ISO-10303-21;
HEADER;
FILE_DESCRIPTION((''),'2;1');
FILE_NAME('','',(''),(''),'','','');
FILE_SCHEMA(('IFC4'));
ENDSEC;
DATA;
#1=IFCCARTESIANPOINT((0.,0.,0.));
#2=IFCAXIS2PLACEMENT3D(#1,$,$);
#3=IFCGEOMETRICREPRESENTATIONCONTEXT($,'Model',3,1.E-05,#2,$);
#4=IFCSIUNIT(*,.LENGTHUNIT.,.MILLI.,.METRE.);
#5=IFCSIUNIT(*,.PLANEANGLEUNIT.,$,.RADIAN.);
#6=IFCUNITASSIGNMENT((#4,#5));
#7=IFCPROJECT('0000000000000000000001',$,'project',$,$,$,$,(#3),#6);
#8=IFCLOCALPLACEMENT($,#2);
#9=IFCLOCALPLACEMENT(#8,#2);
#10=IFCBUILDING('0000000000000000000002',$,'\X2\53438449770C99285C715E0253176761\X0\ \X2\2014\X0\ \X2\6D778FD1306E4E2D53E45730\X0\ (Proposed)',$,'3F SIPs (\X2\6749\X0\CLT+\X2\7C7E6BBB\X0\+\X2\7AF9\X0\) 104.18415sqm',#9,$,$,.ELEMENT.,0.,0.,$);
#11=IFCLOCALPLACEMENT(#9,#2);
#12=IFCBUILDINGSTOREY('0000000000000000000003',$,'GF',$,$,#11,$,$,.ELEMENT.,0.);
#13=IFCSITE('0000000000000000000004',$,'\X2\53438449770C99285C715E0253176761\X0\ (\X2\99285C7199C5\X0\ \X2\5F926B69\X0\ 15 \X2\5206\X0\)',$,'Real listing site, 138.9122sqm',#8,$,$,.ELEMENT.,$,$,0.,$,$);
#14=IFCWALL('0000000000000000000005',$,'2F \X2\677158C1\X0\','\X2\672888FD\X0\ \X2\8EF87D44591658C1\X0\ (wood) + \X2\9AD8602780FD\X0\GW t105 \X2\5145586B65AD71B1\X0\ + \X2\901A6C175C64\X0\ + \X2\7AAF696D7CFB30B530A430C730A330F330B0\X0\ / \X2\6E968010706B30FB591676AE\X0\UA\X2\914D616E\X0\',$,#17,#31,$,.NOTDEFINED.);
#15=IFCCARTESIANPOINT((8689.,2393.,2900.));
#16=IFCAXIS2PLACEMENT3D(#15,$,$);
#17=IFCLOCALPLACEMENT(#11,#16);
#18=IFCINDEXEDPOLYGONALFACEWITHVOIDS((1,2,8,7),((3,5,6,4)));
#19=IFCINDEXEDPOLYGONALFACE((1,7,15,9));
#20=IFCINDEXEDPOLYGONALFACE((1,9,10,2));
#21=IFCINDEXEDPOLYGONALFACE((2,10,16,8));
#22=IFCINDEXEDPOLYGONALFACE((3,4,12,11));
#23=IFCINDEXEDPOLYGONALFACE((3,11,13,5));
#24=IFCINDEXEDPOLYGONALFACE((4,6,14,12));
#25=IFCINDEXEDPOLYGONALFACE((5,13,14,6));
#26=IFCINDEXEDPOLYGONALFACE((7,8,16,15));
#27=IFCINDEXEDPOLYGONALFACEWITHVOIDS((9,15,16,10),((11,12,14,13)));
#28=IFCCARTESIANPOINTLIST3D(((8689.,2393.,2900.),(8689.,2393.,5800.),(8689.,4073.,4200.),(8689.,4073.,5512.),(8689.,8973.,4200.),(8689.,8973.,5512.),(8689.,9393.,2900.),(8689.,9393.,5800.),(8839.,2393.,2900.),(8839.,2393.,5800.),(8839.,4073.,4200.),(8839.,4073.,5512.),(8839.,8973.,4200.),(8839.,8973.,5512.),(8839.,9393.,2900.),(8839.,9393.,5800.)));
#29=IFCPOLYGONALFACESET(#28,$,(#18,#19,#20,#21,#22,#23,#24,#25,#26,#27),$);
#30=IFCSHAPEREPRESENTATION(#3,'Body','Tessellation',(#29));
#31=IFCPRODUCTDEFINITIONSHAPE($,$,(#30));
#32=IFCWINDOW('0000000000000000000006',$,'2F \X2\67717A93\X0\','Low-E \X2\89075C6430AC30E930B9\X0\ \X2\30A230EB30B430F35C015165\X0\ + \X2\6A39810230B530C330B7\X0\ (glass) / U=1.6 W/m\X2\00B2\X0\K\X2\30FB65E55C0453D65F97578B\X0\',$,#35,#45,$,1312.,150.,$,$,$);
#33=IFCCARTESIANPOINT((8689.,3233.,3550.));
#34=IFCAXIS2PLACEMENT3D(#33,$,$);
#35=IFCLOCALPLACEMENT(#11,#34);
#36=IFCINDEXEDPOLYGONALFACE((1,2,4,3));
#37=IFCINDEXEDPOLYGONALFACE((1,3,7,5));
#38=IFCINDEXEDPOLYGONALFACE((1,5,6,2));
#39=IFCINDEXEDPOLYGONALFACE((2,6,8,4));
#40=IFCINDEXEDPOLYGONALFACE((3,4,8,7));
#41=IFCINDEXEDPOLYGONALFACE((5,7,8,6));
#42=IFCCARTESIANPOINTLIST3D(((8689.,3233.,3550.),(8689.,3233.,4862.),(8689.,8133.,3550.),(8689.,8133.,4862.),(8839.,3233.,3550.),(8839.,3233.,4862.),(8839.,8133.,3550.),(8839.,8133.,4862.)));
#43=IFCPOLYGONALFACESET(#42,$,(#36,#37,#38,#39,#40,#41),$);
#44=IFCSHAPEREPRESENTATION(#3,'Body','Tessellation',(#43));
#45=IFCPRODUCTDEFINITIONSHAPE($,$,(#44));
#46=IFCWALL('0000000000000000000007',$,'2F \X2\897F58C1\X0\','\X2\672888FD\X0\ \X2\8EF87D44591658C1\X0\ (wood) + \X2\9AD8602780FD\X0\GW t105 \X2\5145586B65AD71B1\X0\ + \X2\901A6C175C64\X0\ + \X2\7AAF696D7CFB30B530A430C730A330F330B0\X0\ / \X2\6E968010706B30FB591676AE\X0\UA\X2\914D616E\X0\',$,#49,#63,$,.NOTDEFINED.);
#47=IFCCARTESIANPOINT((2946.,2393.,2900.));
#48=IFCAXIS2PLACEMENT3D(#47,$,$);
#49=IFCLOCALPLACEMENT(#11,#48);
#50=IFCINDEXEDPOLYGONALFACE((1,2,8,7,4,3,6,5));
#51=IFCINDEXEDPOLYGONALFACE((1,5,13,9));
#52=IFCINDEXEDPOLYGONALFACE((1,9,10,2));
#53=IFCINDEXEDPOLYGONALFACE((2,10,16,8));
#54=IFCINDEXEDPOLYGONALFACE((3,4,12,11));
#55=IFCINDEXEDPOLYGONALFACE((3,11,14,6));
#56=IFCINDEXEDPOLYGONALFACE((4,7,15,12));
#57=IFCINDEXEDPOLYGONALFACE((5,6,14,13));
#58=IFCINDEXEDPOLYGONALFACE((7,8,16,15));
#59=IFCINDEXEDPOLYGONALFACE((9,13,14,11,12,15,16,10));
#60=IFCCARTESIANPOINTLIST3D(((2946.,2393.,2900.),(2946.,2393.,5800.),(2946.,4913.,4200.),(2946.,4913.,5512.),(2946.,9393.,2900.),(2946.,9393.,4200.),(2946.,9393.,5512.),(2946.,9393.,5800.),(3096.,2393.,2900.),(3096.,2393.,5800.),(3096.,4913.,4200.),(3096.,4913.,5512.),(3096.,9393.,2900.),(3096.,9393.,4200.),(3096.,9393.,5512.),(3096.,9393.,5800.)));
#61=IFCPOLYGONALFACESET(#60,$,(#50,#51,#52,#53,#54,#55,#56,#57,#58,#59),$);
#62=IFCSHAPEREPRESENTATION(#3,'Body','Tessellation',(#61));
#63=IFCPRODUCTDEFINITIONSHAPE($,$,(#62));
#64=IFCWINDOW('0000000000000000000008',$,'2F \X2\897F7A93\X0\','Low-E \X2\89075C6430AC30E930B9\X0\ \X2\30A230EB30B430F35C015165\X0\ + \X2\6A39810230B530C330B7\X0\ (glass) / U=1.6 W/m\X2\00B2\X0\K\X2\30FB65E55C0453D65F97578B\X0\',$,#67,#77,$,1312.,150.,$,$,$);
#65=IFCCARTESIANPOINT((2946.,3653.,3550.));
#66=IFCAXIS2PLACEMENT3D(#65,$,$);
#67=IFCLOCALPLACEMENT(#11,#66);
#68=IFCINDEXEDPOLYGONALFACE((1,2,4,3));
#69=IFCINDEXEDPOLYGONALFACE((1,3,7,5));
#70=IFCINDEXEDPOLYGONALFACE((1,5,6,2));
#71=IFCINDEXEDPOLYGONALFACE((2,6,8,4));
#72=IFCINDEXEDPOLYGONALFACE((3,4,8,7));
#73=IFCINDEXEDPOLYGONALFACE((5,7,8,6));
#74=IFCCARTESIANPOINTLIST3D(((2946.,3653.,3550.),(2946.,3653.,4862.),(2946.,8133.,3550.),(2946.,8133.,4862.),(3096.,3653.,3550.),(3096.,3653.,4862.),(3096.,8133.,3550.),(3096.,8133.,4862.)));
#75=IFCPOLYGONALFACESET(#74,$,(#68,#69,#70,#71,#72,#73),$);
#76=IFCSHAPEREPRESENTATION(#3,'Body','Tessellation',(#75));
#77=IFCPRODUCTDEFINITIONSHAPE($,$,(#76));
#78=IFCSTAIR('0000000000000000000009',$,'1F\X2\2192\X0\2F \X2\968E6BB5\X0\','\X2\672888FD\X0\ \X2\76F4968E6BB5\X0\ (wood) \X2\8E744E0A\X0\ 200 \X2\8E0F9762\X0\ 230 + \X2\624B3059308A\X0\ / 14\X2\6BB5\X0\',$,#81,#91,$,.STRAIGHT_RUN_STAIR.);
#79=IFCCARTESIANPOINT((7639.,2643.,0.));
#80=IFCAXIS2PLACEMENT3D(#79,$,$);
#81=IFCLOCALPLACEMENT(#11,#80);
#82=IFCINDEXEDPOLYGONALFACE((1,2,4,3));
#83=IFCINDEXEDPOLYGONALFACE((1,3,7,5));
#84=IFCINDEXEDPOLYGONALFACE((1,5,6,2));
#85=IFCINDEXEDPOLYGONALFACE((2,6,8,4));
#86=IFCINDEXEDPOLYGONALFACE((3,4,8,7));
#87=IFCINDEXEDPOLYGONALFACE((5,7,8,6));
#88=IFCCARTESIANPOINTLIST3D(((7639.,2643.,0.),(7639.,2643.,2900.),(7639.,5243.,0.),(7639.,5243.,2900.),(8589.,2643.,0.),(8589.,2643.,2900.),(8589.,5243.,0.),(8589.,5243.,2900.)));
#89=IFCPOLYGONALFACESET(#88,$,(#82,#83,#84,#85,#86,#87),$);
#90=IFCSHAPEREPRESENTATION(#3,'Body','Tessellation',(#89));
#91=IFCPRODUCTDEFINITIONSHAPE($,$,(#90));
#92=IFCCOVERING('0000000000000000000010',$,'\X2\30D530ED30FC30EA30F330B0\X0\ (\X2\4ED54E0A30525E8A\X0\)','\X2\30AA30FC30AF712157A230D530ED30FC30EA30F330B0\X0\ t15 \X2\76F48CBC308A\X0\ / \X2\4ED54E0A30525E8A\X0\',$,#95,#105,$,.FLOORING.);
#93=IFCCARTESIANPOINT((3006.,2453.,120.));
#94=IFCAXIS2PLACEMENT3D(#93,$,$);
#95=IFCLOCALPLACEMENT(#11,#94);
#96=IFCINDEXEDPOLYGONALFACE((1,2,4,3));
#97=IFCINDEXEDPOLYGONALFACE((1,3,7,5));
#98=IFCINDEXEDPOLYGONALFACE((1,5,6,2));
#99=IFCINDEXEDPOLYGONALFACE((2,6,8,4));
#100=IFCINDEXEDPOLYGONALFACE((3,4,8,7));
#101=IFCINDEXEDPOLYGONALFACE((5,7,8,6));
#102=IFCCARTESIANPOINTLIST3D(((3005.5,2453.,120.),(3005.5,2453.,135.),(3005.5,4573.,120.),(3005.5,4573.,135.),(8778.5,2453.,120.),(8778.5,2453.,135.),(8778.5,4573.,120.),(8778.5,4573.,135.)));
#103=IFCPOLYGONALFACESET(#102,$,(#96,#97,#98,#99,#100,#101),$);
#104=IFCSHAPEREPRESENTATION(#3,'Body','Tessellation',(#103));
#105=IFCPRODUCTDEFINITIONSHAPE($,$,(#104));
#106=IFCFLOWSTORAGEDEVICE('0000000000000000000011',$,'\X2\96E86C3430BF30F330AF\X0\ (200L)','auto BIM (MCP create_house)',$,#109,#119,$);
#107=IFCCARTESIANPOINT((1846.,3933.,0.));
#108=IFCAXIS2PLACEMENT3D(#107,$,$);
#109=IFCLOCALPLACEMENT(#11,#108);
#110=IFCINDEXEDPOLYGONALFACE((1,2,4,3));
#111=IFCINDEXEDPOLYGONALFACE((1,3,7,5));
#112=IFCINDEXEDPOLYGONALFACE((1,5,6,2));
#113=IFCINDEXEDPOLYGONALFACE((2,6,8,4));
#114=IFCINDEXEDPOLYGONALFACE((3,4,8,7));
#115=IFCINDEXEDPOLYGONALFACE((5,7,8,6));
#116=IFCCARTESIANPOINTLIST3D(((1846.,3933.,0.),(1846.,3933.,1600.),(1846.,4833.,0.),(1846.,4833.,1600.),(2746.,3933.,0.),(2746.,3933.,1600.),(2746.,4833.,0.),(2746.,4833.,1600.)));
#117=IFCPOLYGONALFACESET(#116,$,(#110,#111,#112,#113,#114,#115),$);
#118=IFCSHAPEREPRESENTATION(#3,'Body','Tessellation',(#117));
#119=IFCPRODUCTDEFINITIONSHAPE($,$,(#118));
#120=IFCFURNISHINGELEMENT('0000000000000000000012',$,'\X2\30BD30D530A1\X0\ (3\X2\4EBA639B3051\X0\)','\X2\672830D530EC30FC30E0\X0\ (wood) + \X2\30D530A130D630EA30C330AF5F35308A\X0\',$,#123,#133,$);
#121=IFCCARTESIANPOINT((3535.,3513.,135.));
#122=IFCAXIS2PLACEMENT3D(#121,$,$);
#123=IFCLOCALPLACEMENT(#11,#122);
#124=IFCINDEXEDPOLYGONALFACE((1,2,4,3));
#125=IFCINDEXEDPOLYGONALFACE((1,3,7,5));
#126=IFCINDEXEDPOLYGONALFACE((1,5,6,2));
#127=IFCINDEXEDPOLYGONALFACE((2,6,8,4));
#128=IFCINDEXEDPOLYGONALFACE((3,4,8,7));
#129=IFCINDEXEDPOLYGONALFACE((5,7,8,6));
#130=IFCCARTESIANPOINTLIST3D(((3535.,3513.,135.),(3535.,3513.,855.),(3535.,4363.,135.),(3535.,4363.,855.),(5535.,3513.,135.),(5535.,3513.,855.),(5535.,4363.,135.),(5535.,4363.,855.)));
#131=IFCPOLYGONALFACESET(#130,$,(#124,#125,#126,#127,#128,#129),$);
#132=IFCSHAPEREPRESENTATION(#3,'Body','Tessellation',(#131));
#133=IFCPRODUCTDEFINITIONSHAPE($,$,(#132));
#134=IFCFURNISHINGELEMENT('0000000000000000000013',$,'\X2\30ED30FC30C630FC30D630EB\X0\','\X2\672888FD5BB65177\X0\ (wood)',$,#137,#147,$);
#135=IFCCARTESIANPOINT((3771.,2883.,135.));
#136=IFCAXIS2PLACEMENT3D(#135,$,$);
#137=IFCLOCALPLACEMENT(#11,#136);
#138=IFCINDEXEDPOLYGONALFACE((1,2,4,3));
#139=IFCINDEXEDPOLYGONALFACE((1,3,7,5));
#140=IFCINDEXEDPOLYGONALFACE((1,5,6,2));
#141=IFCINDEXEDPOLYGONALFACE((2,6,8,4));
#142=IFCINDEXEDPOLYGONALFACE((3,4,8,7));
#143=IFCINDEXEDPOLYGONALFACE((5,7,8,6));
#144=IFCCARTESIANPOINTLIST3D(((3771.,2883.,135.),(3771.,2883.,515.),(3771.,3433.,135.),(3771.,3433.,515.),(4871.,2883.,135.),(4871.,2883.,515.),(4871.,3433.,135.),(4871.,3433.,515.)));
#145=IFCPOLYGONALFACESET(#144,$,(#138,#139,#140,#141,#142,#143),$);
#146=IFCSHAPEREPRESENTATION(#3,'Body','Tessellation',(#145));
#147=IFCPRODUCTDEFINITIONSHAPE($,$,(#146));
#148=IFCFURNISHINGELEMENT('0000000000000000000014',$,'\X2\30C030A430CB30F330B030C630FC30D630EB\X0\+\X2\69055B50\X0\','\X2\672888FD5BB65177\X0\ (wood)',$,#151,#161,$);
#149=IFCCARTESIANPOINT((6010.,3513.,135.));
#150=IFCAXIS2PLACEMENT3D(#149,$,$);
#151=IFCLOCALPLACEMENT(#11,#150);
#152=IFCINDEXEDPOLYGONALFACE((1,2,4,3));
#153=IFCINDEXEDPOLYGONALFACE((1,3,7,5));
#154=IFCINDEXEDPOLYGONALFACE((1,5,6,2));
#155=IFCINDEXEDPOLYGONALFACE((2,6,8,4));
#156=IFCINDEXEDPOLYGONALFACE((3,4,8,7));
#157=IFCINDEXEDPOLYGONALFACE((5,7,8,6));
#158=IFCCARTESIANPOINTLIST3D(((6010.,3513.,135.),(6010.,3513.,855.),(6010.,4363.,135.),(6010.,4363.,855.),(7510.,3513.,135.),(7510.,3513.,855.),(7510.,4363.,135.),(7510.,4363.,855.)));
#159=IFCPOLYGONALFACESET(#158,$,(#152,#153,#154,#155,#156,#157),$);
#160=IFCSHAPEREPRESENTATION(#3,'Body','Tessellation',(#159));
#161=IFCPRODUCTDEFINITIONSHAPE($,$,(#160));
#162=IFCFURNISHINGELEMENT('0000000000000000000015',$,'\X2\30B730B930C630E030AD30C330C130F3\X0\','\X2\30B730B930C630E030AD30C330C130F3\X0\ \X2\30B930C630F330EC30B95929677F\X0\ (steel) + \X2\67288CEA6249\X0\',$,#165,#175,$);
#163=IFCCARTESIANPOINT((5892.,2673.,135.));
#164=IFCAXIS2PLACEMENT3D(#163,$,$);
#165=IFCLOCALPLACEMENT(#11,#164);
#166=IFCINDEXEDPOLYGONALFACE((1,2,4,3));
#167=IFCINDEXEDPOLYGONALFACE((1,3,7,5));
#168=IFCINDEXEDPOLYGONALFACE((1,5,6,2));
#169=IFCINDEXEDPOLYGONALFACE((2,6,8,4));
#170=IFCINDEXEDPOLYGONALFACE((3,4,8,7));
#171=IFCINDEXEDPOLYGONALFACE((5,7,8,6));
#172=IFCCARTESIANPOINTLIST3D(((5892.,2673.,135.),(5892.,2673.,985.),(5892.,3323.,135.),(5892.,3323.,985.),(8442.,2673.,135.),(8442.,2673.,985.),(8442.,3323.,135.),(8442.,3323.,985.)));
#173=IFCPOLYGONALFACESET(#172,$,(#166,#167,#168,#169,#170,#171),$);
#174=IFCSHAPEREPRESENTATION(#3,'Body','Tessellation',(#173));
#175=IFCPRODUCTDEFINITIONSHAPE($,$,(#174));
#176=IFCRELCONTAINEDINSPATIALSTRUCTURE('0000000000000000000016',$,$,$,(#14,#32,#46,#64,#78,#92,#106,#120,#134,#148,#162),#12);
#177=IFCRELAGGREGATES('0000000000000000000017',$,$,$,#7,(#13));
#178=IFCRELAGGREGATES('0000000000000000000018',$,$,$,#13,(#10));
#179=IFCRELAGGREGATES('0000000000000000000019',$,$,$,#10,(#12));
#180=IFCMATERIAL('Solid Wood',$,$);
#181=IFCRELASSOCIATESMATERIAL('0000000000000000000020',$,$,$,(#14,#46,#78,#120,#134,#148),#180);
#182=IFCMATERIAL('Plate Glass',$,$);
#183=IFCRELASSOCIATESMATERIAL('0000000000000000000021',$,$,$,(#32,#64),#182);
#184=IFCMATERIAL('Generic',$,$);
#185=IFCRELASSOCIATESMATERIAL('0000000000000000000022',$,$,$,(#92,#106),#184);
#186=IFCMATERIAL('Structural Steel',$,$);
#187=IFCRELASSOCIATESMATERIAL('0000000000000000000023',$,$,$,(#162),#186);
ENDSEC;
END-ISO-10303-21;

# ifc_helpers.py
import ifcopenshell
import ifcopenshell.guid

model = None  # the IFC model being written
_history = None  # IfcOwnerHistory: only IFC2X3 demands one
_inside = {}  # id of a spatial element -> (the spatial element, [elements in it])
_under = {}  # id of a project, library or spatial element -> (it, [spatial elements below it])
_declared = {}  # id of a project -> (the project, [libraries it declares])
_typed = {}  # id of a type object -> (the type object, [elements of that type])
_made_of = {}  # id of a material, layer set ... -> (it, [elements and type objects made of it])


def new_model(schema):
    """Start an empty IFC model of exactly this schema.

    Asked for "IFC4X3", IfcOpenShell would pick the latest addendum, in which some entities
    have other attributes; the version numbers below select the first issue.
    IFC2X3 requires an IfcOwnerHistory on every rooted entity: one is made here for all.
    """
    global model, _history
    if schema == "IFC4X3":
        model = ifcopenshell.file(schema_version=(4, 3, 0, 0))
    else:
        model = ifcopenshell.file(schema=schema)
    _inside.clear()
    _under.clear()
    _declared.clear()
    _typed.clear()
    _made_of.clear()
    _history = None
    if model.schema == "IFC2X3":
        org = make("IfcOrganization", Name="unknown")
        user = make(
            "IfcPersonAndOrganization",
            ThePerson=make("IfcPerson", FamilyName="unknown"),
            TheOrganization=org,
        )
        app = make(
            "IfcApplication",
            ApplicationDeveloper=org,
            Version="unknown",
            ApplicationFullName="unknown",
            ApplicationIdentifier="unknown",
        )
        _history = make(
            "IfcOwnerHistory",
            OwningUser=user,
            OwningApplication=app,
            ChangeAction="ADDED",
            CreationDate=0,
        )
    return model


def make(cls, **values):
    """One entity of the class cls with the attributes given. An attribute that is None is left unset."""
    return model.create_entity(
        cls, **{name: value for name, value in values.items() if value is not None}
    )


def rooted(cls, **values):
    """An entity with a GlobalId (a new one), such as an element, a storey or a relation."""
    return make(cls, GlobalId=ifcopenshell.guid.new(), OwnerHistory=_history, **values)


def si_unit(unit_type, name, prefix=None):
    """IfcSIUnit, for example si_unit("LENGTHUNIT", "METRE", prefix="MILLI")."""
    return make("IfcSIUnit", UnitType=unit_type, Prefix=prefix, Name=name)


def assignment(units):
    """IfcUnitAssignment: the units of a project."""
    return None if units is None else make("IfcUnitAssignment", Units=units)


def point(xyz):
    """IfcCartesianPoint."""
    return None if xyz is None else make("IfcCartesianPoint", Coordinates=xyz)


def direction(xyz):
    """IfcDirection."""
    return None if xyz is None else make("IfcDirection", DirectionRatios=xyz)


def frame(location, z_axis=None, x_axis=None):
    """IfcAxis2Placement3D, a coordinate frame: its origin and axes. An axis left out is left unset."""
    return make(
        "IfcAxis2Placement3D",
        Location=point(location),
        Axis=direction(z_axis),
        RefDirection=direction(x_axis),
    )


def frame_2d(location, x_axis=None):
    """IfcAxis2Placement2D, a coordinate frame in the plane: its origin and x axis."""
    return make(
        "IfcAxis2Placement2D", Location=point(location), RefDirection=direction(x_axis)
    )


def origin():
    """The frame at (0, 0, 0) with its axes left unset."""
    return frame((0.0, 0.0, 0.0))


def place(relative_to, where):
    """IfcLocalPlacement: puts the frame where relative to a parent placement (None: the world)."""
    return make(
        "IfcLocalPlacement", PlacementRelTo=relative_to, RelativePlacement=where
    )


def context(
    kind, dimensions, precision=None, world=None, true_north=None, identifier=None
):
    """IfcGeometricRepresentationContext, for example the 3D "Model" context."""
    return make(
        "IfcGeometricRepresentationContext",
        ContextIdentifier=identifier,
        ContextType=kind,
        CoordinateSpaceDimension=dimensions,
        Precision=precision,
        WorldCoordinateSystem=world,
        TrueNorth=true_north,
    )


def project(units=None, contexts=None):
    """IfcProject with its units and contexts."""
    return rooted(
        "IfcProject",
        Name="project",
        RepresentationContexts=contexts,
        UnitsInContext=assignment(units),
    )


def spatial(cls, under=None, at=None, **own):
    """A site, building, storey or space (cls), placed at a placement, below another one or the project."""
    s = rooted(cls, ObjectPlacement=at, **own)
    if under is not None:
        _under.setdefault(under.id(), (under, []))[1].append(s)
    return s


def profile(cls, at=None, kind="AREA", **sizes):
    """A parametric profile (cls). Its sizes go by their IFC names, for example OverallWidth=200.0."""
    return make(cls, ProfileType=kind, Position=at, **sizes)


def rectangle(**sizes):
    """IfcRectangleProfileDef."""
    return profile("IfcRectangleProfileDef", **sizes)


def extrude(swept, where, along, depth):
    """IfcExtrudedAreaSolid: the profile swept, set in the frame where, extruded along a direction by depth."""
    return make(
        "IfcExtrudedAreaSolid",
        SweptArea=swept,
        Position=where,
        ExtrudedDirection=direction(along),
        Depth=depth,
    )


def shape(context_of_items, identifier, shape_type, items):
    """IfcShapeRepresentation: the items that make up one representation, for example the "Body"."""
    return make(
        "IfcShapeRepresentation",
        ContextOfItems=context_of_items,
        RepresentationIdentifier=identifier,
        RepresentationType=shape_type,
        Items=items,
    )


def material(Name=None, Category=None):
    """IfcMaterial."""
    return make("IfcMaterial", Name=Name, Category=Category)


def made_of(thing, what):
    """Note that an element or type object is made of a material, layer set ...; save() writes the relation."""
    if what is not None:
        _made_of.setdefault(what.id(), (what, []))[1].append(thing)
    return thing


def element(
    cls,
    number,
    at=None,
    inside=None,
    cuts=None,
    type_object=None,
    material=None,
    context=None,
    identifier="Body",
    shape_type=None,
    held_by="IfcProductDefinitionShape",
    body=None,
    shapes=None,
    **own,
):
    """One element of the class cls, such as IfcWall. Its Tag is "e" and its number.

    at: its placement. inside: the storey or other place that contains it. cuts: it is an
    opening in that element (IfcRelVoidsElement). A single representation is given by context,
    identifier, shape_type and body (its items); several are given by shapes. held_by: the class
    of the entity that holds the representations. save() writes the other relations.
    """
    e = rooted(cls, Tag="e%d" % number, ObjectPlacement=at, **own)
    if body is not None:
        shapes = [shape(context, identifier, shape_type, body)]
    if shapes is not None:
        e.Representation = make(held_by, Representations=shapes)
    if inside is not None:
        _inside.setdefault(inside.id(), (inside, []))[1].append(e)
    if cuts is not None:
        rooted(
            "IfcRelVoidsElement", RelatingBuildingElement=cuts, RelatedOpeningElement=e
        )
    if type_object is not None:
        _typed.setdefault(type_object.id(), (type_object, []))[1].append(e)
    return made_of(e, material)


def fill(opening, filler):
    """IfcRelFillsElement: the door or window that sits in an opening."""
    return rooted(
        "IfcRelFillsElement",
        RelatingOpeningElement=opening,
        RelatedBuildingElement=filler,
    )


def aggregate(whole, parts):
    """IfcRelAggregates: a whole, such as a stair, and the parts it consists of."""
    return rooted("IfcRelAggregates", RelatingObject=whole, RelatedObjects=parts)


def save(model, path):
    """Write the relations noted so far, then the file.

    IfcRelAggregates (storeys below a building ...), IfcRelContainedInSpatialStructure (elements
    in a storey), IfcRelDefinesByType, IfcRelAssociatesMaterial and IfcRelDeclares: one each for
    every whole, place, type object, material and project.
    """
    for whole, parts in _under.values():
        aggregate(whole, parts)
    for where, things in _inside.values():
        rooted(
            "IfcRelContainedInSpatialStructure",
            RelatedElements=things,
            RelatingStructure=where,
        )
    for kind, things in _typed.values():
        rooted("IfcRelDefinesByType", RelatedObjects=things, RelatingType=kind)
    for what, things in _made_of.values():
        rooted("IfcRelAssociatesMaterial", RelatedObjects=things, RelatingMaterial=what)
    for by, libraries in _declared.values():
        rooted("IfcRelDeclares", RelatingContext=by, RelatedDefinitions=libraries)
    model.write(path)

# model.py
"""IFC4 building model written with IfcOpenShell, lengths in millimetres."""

from ifc_helpers import new_model, si_unit, frame, frame_2d, origin, place, context, project, spatial, rectangle, extrude, material, element, fill, save


model = new_model("IFC4")

# Units and contexts
model_context = context("Model", 3, precision=1e-05, world=origin())
ifc_project = project(units=[si_unit("LENGTHUNIT", "METRE", prefix="MILLI"), si_unit("PLANEANGLEUNIT", "RADIAN")], contexts=[model_context])

# Site, building, storey
site_placement = place(None, origin())
site = spatial("IfcSite", under=ifc_project, at=site_placement, Name="千葉県館山市北条 (館山駅 徒歩 15 分)", ObjectType="Real listing site, 138.9122sqm", CompositionType="ELEMENT", RefElevation=0.0)
building_placement = place(site_placement, origin())
building = spatial("IfcBuilding", under=site, at=building_placement, Name="千葉県館山市北条 — 海近の中古地 (Proposed)", ObjectType="3F SIPs (杉CLT+籾殻+竹) 104.18415sqm", CompositionType="ELEMENT", ElevationOfRefHeight=0.0, ElevationOfTerrain=0.0)
storey_placement = place(building_placement, origin())
storey = spatial("IfcBuildingStorey", under=building, at=storey_placement, Name="GF", CompositionType="ELEMENT", Elevation=0.0)

# Shared definitions
ifc_material_1 = material(Name="Solid Wood")

# Shared definitions
ifc_material_2 = material(Name="Plate Glass")

# Walls, openings, windows
wall_1_placement = place(storey_placement, frame((8689.0, 2393.0, 2900.0)))
wall_1 = element("IfcWall", 1, at=wall_1_placement, inside=storey, material=ifc_material_1, Name="2F 東壁", Description="木製 軸組外壁 (wood) + 高性能GW t105 充填断熱 + 通気層 + 窯業系サイディング / 準耐火・外皮UA配慮", PredefinedType="NOTDEFINED", context=model_context, shape_type="SweptSolid", body=[
    extrude(rectangle(XDim=150.0, YDim=7000.0, at=frame_2d((75.0, 3500.0))), frame((8689.0, 2393.0, 2900.0)), (0.0, 0.0, 1.0), 2900.0),
])
opening_1_placement = place(storey_placement, frame((8689.0, 3233.0, 3550.0)))
opening_1 = element("IfcOpeningElement", 2, at=opening_1_placement, cuts=wall_1, PredefinedType="NOTDEFINED", context=model_context, shape_type="SweptSolid", body=[
    extrude(rectangle(XDim=150.0, YDim=4900.0, at=frame_2d((75.0, 2450.0))), frame((8689.0, 3233.0, 3550.0)), (0.0, 0.0, 1.0), 1312.0),
])
window_1_placement = place(storey_placement, frame((8689.0, 3233.0, 3550.0)))
window_1 = element("IfcWindow", 3, at=window_1_placement, inside=storey, material=ifc_material_2, Name="2F 東窓", Description="Low-E 複層ガラス アルゴン封入 + 樹脂サッシ (glass) / U=1.6 W/m²K・日射取得型", OverallHeight=1312.0, OverallWidth=150.0, context=model_context, shape_type="SweptSolid", body=[
    extrude(rectangle(XDim=150.0, YDim=4900.0, at=frame_2d((75.0, 2450.0))), frame((8689.0, 3233.0, 3550.0)), (0.0, 0.0, 1.0), 1312.0),
])
fill(opening_1, window_1)
wall_2_placement = place(storey_placement, frame((2946.0, 2393.0, 2900.0)))
wall_2 = element("IfcWall", 4, at=wall_2_placement, inside=storey, material=ifc_material_1, Name="2F 西壁", Description="木製 軸組外壁 (wood) + 高性能GW t105 充填断熱 + 通気層 + 窯業系サイディング / 準耐火・外皮UA配慮", PredefinedType="NOTDEFINED", context=model_context, shape_type="SweptSolid", body=[
    extrude(rectangle(XDim=150.0, YDim=7000.0, at=frame_2d((75.0, 3500.0))), frame((2946.0, 2393.0, 2900.0)), (0.0, 0.0, 1.0), 2900.0),
])
opening_2_placement = place(storey_placement, frame((2946.0, 3653.0, 3550.0)))
opening_2 = element("IfcOpeningElement", 5, at=opening_2_placement, cuts=wall_2, PredefinedType="NOTDEFINED", context=model_context, shape_type="SweptSolid", body=[
    extrude(rectangle(XDim=150.0, YDim=4480.0, at=frame_2d((75.0, 2240.0))), frame((2946.0, 3653.0, 3550.0)), (0.0, 0.0, 1.0), 1312.0),
])
window_2_placement = place(storey_placement, frame((2946.0, 3653.0, 3550.0)))
window_2 = element("IfcWindow", 6, at=window_2_placement, inside=storey, material=ifc_material_2, Name="2F 西窓", Description="Low-E 複層ガラス アルゴン封入 + 樹脂サッシ (glass) / U=1.6 W/m²K・日射取得型", OverallHeight=1312.0, OverallWidth=150.0, context=model_context, shape_type="SweptSolid", body=[
    extrude(rectangle(XDim=150.0, YDim=4480.0, at=frame_2d((75.0, 2240.0))), frame((2946.0, 3653.0, 3550.0)), (0.0, 0.0, 1.0), 1312.0),
])
fill(opening_2, window_2)

# Stair
stair_placement = place(storey_placement, frame((7639.0, 2643.0, 0.0)))
element("IfcStair", 7, at=stair_placement, inside=storey, material=ifc_material_1, Name="1F→2F 階段", Description="木製 直階段 (wood) 蹴上 200 踏面 230 + 手すり / 14段", PredefinedType="STRAIGHT_RUN_STAIR", context=model_context, shape_type="SweptSolid", body=[
    extrude(rectangle(XDim=950.0, YDim=2600.0, at=frame_2d((475.0, 1300.0))), frame((7639.0, 2643.0, 0.0)), (0.0, 0.0, 1.0), 2900.0),
])

# Covering
ifc_material_3 = material(Name="Generic")
covering_placement = place(storey_placement, frame((3006.0, 2453.0, 120.0)))
element("IfcCovering", 8, at=covering_placement, inside=storey, material=ifc_material_3, Name="フローリング (仕上げ床)", Description="オーク無垢フローリング t15 直貼り / 仕上げ床", PredefinedType="FLOORING", context=model_context, shape_type="SweptSolid", body=[
    extrude(rectangle(XDim=5773.0, YDim=2120.0, at=frame_2d((2886.0, 1060.0))), frame((3006.0, 2453.0, 120.0)), (0.0, 0.0, 1.0), 15.0),
])

# Flow storage device
flow_storage_device_placement = place(storey_placement, frame((1846.0, 3933.0, 0.0)))
element("IfcFlowStorageDevice", 9, at=flow_storage_device_placement, inside=storey, material=ifc_material_3, Name="雨水タンク (200L)", Description="auto BIM (MCP create_house)", context=model_context, shape_type="SweptSolid", body=[
    extrude(rectangle(XDim=900.0, YDim=900.0, at=frame_2d((450.0, 450.0))), frame((1846.0, 3933.0, 0.0)), (0.0, 0.0, 1.0), 1600.0),
])

# Furnishing elements
furnishing_1_placement = place(storey_placement, frame((3535.0, 3513.0, 135.0)))
element("IfcFurnishingElement", 10, at=furnishing_1_placement, inside=storey, material=ifc_material_1, Name="ソファ (3人掛け)", Description="木フレーム (wood) + ファブリック張り", context=model_context, shape_type="SweptSolid", body=[
    extrude(rectangle(XDim=2000.0, YDim=850.0, at=frame_2d((1000.0, 425.0))), frame((3535.0, 3513.0, 135.0)), (0.0, 0.0, 1.0), 720.0),
])
furnishing_2_placement = place(storey_placement, frame((3771.0, 2883.0, 135.0)))
element("IfcFurnishingElement", 11, at=furnishing_2_placement, inside=storey, material=ifc_material_1, Name="ローテーブル", Description="木製家具 (wood)", context=model_context, shape_type="SweptSolid", body=[
    extrude(rectangle(XDim=1100.0, YDim=550.0, at=frame_2d((550.0, 275.0))), frame((3771.0, 2883.0, 135.0)), (0.0, 0.0, 1.0), 380.0),
])
furnishing_3_placement = place(storey_placement, frame((6010.0, 3513.0, 135.0)))
element("IfcFurnishingElement", 12, at=furnishing_3_placement, inside=storey, material=ifc_material_1, Name="ダイニングテーブル+椅子", Description="木製家具 (wood)", context=model_context, shape_type="SweptSolid", body=[
    extrude(rectangle(XDim=1500.0, YDim=850.0, at=frame_2d((750.0, 425.0))), frame((6010.0, 3513.0, 135.0)), (0.0, 0.0, 1.0), 720.0),
])
ifc_material_4 = material(Name="Structural Steel")
furnishing_4_placement = place(storey_placement, frame((5892.0, 2673.0, 135.0)))
element("IfcFurnishingElement", 13, at=furnishing_4_placement, inside=storey, material=ifc_material_4, Name="システムキッチン", Description="システムキッチン ステンレス天板 (steel) + 木質扉", context=model_context, shape_type="SweptSolid", body=[
    extrude(rectangle(XDim=2550.0, YDim=650.0, at=frame_2d((1275.0, 325.0))), frame((5892.0, 2673.0, 135.0)), (0.0, 0.0, 1.0), 850.0),
])

save(model, "model.ifc")
